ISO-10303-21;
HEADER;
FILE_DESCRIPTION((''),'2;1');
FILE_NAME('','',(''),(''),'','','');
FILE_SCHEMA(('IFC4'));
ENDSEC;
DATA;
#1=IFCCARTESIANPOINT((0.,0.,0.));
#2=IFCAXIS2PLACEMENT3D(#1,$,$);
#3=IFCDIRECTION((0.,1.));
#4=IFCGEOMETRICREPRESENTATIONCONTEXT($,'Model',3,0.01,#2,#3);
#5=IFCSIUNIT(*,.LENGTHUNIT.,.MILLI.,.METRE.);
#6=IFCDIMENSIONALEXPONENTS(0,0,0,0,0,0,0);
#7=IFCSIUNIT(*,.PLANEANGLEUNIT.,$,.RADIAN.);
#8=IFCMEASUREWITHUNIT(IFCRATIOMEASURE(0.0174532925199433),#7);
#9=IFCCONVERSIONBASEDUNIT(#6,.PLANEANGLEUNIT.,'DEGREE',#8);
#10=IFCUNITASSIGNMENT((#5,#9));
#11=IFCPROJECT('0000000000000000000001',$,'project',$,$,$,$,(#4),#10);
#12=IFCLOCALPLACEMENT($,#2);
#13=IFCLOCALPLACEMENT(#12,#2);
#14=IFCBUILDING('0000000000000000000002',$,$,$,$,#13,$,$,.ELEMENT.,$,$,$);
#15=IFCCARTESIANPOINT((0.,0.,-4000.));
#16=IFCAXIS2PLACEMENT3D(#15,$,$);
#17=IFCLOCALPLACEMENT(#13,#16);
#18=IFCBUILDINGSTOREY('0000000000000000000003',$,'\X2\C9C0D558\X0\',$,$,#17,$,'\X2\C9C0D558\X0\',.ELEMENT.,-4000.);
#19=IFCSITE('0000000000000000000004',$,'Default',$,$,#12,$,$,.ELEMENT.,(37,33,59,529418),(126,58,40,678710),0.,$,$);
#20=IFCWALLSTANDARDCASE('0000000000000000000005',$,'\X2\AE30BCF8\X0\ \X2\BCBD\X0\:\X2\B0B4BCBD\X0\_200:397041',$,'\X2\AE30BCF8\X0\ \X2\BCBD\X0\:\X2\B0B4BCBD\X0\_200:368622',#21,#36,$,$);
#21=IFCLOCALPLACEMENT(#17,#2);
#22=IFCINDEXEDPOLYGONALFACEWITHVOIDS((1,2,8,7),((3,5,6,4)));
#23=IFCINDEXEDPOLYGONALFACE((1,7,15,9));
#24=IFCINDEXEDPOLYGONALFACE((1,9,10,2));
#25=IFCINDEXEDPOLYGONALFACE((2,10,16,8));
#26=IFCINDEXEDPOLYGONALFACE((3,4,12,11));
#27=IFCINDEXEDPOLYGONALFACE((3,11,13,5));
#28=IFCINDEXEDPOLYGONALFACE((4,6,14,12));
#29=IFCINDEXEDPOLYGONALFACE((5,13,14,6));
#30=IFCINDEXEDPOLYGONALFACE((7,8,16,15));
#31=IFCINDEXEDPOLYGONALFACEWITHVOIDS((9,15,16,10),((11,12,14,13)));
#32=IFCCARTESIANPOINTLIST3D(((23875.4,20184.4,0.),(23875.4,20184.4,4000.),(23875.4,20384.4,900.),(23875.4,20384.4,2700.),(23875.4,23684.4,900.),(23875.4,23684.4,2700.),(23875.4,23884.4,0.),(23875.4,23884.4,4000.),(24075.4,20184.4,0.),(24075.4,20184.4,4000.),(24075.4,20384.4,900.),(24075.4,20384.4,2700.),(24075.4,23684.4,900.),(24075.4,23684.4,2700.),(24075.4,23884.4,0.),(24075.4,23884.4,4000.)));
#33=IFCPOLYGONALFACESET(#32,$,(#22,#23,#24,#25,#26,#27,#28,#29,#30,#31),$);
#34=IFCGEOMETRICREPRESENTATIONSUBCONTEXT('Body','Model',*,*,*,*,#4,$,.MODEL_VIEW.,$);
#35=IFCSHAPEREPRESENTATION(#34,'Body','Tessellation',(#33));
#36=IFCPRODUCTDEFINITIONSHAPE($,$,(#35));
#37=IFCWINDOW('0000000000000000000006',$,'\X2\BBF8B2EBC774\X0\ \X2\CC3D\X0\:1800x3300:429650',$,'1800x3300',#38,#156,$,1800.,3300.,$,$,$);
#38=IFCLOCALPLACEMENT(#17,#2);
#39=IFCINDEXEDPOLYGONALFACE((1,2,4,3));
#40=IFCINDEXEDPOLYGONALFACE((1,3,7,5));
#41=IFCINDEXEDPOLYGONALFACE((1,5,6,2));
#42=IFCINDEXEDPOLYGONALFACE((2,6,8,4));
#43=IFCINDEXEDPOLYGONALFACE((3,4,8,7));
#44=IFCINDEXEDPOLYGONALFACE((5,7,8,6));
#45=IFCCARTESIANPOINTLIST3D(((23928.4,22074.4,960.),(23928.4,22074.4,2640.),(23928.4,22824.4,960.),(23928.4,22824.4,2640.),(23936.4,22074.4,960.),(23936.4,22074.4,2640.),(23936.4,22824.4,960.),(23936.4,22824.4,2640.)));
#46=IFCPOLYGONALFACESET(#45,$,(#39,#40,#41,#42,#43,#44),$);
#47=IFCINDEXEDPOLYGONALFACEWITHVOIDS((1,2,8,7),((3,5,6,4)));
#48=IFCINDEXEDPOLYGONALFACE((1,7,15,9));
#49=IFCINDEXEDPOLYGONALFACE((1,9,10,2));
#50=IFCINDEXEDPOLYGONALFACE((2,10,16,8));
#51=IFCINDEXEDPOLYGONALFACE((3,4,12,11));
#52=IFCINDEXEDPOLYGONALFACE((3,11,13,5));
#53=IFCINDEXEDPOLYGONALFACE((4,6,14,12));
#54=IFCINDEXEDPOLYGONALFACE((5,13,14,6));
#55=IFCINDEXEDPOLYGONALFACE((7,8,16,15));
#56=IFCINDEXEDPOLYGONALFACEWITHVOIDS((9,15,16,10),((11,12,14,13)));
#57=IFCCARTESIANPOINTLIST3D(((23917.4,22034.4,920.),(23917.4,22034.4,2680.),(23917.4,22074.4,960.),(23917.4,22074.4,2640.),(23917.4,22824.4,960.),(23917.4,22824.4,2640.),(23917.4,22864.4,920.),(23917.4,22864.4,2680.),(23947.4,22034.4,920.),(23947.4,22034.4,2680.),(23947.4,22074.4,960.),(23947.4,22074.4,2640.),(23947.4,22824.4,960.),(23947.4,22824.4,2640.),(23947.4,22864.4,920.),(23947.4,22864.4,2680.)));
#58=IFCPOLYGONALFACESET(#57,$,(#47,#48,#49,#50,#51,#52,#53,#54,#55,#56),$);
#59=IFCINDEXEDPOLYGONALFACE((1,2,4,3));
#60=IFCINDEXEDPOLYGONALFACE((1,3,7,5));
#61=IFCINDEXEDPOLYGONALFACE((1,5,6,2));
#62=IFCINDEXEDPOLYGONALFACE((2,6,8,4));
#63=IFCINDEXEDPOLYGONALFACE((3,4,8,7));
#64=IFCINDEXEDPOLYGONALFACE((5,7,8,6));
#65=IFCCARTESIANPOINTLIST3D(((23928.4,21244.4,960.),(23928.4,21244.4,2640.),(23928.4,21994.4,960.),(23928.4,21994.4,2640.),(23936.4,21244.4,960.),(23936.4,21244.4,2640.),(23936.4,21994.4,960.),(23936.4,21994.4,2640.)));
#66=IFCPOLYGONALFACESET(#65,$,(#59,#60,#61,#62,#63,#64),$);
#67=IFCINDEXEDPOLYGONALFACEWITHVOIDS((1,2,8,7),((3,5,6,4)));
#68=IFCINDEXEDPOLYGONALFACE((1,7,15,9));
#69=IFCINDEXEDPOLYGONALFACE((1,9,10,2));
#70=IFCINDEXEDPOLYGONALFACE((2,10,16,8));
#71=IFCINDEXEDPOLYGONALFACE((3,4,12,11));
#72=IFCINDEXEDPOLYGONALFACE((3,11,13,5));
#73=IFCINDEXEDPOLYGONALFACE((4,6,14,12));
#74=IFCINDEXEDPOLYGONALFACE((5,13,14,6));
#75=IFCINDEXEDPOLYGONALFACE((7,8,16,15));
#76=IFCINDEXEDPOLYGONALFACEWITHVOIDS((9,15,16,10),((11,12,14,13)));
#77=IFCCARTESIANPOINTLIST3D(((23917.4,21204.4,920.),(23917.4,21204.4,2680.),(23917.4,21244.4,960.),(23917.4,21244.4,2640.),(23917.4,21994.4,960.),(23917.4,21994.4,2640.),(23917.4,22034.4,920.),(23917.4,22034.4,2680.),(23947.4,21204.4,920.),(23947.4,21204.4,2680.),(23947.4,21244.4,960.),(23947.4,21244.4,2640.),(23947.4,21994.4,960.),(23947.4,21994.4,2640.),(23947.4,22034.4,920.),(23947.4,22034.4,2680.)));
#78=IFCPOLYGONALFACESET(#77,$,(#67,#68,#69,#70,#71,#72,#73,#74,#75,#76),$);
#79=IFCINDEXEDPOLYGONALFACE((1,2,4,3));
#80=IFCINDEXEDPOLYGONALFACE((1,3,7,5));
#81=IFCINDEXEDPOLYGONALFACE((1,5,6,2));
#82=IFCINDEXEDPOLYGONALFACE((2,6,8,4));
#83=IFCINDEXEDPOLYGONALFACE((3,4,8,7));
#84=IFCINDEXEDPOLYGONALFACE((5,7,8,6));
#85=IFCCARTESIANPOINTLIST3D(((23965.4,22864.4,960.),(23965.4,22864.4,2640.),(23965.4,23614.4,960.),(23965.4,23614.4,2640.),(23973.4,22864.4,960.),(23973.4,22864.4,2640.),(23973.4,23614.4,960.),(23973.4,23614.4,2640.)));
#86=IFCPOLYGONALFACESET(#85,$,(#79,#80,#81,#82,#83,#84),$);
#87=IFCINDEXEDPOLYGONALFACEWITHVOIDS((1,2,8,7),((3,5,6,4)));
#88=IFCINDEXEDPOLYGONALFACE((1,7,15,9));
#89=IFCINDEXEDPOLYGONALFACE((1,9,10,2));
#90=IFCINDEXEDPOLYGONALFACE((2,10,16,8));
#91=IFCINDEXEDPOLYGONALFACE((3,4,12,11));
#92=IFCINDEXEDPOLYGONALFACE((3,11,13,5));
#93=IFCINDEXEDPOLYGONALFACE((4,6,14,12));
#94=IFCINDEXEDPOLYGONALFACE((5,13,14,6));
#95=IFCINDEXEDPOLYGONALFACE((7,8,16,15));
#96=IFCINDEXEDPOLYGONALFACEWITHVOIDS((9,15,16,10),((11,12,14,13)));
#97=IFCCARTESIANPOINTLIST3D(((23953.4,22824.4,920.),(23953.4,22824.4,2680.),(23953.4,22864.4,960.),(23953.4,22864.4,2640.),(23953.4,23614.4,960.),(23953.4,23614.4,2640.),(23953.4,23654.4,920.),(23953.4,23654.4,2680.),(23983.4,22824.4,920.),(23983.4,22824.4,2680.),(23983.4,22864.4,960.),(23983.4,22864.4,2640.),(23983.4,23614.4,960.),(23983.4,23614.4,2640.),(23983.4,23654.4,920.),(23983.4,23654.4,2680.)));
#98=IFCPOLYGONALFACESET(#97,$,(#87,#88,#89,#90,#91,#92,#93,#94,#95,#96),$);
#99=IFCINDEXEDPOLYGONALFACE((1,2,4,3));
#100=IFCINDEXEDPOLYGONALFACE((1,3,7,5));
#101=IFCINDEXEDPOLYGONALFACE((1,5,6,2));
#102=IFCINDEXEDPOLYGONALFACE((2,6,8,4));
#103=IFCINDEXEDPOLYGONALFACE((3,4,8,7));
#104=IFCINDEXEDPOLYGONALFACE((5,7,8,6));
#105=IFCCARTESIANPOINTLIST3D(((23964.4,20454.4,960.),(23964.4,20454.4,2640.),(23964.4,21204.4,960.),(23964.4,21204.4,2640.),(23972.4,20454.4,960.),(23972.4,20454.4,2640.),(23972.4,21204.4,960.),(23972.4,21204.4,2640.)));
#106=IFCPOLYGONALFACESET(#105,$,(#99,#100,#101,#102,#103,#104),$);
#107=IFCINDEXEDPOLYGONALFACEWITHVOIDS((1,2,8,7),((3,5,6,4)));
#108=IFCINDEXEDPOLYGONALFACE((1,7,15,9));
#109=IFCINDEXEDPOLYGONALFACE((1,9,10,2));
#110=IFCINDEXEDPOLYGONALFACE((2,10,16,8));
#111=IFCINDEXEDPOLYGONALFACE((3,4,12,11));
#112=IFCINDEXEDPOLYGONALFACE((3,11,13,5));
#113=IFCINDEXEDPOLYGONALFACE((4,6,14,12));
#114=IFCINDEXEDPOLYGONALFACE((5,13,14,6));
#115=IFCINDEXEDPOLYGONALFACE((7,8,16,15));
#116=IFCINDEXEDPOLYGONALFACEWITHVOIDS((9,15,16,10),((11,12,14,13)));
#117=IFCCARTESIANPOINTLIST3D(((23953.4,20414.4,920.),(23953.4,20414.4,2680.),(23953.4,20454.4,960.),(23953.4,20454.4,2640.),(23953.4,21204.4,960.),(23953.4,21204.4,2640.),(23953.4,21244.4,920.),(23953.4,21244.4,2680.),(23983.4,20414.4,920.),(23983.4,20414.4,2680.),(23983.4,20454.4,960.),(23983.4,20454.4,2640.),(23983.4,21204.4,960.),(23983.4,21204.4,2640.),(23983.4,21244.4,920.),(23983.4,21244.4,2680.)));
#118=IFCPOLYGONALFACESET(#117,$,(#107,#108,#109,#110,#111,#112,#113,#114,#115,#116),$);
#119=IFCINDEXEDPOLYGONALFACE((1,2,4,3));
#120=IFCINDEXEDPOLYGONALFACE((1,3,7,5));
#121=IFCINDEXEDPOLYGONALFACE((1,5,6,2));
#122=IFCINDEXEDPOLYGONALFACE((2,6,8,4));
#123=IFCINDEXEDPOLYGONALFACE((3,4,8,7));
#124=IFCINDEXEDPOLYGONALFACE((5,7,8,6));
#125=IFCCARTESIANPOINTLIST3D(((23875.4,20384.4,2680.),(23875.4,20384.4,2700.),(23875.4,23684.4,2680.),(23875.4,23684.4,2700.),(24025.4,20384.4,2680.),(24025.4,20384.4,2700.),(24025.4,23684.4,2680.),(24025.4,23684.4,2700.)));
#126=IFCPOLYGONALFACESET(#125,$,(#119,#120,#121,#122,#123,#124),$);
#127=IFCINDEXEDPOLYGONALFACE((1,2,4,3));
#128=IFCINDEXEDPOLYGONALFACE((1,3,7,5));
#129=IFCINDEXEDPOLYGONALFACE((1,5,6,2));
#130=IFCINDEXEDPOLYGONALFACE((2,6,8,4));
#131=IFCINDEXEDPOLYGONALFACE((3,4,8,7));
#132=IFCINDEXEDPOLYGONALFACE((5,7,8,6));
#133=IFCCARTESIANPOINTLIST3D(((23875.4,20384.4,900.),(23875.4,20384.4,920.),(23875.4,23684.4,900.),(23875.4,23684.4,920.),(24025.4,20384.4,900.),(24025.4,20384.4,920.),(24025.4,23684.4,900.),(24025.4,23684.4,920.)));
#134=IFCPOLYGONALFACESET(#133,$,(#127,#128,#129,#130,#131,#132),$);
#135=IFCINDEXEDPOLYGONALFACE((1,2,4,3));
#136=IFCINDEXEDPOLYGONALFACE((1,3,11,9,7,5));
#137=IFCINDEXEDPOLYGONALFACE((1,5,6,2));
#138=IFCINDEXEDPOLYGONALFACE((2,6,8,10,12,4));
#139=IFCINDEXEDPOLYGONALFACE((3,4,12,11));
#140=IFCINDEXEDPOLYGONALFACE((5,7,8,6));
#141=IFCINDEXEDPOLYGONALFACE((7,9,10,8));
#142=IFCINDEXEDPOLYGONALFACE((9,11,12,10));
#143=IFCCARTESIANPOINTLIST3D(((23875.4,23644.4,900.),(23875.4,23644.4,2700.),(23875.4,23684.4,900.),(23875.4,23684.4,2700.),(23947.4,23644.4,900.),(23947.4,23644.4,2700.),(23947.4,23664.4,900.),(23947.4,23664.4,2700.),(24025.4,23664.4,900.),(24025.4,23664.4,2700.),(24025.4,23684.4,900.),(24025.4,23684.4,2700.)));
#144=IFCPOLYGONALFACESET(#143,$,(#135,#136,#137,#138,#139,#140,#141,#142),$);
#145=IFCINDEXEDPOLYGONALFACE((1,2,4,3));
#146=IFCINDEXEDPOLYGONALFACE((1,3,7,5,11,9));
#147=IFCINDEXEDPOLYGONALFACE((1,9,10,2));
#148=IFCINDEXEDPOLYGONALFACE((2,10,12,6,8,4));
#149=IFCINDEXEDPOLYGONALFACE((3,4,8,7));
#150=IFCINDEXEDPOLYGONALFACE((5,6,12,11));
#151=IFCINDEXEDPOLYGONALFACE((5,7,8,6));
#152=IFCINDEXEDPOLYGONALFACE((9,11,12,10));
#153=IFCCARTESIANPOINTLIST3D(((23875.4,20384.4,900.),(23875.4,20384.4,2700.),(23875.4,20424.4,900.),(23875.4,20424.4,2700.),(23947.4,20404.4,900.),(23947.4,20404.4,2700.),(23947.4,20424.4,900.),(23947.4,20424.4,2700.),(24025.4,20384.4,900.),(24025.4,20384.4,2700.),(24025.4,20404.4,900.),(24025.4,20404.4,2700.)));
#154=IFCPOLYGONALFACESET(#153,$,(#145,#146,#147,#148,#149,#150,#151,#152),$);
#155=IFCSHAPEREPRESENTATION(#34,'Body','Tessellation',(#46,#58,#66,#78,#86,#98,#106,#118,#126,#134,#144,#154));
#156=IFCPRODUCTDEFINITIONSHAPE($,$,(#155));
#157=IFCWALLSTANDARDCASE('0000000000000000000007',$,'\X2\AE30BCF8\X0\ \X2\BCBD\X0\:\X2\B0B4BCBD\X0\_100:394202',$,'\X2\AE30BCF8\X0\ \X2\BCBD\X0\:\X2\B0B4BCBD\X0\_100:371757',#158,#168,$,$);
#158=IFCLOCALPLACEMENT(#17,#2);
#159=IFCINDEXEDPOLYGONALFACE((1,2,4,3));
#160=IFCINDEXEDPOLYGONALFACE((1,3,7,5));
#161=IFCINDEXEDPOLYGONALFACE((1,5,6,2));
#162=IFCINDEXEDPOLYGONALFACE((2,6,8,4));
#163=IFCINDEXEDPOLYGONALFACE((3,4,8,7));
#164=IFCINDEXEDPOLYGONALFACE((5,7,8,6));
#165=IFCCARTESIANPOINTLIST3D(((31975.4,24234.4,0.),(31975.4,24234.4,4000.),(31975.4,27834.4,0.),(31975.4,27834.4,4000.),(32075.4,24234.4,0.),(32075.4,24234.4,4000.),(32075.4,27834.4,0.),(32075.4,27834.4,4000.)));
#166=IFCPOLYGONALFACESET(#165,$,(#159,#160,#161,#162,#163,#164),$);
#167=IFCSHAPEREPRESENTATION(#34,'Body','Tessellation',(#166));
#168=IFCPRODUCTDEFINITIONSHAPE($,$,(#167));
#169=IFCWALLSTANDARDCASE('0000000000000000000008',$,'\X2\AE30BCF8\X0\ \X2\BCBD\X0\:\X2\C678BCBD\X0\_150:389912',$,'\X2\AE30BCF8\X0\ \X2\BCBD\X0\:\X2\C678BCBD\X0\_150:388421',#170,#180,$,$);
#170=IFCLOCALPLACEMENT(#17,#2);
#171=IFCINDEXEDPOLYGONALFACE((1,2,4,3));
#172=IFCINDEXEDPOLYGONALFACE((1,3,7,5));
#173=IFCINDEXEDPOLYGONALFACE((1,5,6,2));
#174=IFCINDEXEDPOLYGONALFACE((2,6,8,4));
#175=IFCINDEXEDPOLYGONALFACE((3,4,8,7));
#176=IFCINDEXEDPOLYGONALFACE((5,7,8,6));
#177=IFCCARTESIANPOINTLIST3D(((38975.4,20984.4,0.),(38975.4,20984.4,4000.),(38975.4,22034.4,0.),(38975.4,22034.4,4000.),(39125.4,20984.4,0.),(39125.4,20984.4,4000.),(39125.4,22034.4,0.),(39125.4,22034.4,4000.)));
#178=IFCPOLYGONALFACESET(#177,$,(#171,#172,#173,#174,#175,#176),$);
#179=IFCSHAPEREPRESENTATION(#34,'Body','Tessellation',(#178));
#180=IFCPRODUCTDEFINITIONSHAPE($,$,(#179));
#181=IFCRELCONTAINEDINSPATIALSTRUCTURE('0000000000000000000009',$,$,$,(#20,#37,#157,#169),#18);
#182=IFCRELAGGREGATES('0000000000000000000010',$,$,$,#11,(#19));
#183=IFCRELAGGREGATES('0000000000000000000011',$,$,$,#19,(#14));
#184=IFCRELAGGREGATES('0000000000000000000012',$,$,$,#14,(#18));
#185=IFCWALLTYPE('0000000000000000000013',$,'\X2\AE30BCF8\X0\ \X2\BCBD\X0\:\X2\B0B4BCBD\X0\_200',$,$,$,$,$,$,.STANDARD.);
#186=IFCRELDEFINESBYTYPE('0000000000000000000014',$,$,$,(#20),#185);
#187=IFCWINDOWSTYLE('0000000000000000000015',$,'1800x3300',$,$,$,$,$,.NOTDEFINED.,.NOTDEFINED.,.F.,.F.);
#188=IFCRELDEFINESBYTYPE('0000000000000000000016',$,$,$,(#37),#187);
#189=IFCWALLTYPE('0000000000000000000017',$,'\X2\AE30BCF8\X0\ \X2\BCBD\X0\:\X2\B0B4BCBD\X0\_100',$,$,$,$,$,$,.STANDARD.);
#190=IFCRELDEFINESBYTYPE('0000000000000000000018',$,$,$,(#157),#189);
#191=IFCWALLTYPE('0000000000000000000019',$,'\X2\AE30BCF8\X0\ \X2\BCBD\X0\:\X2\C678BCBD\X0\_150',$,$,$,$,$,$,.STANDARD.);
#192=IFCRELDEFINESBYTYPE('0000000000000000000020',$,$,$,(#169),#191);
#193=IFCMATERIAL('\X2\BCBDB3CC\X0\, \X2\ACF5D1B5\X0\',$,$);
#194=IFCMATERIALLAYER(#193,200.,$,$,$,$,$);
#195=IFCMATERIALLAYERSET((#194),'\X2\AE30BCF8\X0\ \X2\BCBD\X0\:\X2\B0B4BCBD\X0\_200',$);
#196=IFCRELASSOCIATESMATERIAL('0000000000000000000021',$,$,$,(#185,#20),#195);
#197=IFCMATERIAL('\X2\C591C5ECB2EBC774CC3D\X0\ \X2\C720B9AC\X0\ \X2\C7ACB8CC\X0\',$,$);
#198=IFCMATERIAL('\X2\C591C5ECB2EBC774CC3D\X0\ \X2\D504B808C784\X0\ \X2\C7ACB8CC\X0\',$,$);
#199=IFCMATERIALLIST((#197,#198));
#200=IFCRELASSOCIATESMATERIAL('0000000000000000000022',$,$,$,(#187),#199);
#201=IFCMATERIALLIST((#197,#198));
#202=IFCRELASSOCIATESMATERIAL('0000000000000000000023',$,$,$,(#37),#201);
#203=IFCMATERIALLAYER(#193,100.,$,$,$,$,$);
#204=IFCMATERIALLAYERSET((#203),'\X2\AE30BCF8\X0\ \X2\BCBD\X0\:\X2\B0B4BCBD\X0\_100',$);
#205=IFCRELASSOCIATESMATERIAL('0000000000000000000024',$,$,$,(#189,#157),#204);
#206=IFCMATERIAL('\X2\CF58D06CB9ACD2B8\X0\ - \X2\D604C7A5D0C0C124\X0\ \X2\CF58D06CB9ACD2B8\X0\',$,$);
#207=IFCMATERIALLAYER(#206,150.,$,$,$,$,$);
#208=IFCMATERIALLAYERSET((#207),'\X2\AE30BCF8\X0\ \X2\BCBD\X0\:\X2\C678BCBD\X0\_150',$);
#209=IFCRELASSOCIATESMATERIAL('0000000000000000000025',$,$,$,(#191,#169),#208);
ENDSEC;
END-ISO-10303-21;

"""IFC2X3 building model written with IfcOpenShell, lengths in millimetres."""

from ifc_helpers import new_model, entity, si_unit, converted_unit, direction, frame, frame_2d, origin, origin_2d_with_axis, place, context, subcontext, project, spatial, polyline, rectangle, outline, extrude, source, transform, mapped, material, material_list, layer, layer_set, layer_usage, type_object, type_shapes, element, fill, save


model = new_model("IFC2X3")

# Units and contexts
model_context = context("Model", 3, precision=0.01, world=origin(), true_north=direction((0.0, 1.0)))
body_context = subcontext(model_context, "Body", "Model", "MODEL_VIEW")
ifc_project = project(units=[si_unit("LENGTHUNIT", "METRE", prefix="MILLI"), converted_unit("PLANEANGLEUNIT", "DEGREE", entity("IfcRatioMeasure", 0.0174532925199433), si_unit("PLANEANGLEUNIT", "RADIAN"), dimensions=[0, 0, 0, 0, 0, 0, 0])], contexts=[model_context])

# Site, building, storey
site_placement = place(None, origin())
site = spatial("IfcSite", under=ifc_project, at=site_placement, Name="Default", CompositionType="ELEMENT", RefLatitude=(37, 33, 59, 529418), RefLongitude=(126, 58, 40, 678710), RefElevation=0.0)
building_placement = place(site_placement, origin())
building = spatial("IfcBuilding", under=site, at=building_placement, CompositionType="ELEMENT")
storey_placement = place(building_placement, frame((0.0, 0.0, -4000.0)))
storey = spatial("IfcBuildingStorey", under=building, at=storey_placement, Name="지하", LongName="지하", CompositionType="ELEMENT", Elevation=-4000.0)

# Shared definitions
ifc_material_1 = material(Name="콘크리트 - 현장타설 콘크리트")

# Shared definitions
ifc_material_2 = material(Name="양여닫이창 유리 재료")
ifc_material_3 = material(Name="양여닫이창 프레임 재료")

# Shared definitions
ifc_material_4 = material(Name="벽돌, 공통")
ifc_layer_1 = layer(ifc_material_4, 200.0)
ifc_layer_set_1 = layer_set([ifc_layer_1], Name="기본 벽:내벽_200")
wall_type_1 = type_object("IfcWallType", Name="기본 벽:내벽_200", PredefinedType="STANDARD", material=ifc_layer_set_1)

# Wall, opening, window
ifc_material_list_1 = material_list([ifc_material_2, ifc_material_3])
window_style_1 = type_object("IfcWindowStyle", Name="1800x3300", ConstructionType="NOTDEFINED", OperationType="NOTDEFINED", ParameterTakesPrecedence=False, Sizeable=False, material=ifc_material_list_1)
shared_shape_1 = source(origin(), body_context, "Body", "SweptSolid", [
    extrude(rectangle(XDim=8.0, YDim=750.0, at=frame_2d((0.0, 0.0), x_axis=(1.0, 0.0))), frame((2065.0, 143.0, 60.0), z_axis=(0.0, 0.0, 1.0), x_axis=(0.0, 1.0, 0.0)), (0.0, 0.0, 1.0), 1680.0),
    extrude(outline(polyline([(-880.0, -415.0), (880.0, -415.0), (880.0, 415.0), (-880.0, 415.0), (-880.0, -415.0)]), holes=[polyline([(840.0, -375.0), (-840.0, -375.0), (-840.0, 375.0), (840.0, 375.0), (840.0, -375.0)])]), frame((2065.0, 128.0, 900.0), z_axis=(0.0, 1.0, 0.0), x_axis=(0.0, 0.0, -1.0)), (0.0, 0.0, 1.0), 30.0),
    extrude(rectangle(XDim=8.0, YDim=750.0, at=frame_2d((0.0, 0.0), x_axis=(1.0, 0.0))), frame((1235.0, 143.0, 60.0), z_axis=(0.0, 0.0, 1.0), x_axis=(0.0, 1.0, 0.0)), (0.0, 0.0, 1.0), 1680.0),
    extrude(outline(polyline([(-880.0, -415.0), (880.0, -415.0), (880.0, 415.0), (-880.0, 415.0), (-880.0, -415.0)]), holes=[polyline([(840.0, -375.0), (-840.0, -375.0), (-840.0, 375.0), (840.0, 375.0), (840.0, -375.0)])]), frame((1235.0, 128.0, 900.0), z_axis=(0.0, 1.0, 0.0), x_axis=(0.0, 0.0, -1.0)), (0.0, 0.0, 1.0), 30.0),
    extrude(rectangle(XDim=8.0, YDim=750.0, at=frame_2d((0.0, 0.0), x_axis=(1.0, 0.0))), frame((2855.0, 106.0, 60.0), z_axis=(0.0, 0.0, 1.0), x_axis=(0.0, 1.0, 0.0)), (0.0, 0.0, 1.0), 1680.0),
    extrude(outline(polyline([(-880.0, -415.0), (880.0, -415.0), (880.0, 415.0), (-880.0, 415.0), (-880.0, -415.0)]), holes=[polyline([(840.0, -375.0), (-840.0, -375.0), (-840.0, 375.0), (840.0, 375.0), (840.0, -375.0)])]), frame((2855.0, 92.0, 900.0), z_axis=(0.0, 1.0, 0.0), x_axis=(0.0, 0.0, -1.0)), (0.0, 0.0, 1.0), 30.0),
    extrude(rectangle(XDim=8.0, YDim=750.0, at=origin_2d_with_axis()), frame((445.0, 107.0, 60.0), z_axis=(0.0, 0.0, 1.0), x_axis=(0.0, 1.0, 0.0)), (0.0, 0.0, 1.0), 1680.0),
    extrude(outline(polyline([(-880.0, -415.0), (880.0, -415.0), (880.0, 415.0), (-880.0, 415.0), (-880.0, -415.0)]), holes=[polyline([(840.0, -375.0), (-840.0, -375.0), (-840.0, 375.0), (840.0, 375.0), (840.0, -375.0)])]), frame((445.0, 92.0, 900.0), z_axis=(0.0, 1.0, 0.0), x_axis=(0.0, 0.0, -1.0)), (0.0, 0.0, 1.0), 30.0),
    extrude(rectangle(XDim=3300.0, YDim=150.0, at=origin_2d_with_axis()), frame((1650.0, 125.0, 1780.0), z_axis=(0.0, 0.0, 1.0), x_axis=(-1.0, 0.0, 0.0)), (0.0, 0.0, 1.0), 20.0),
    extrude(rectangle(XDim=3300.0, YDim=150.0, at=origin_2d_with_axis()), frame((1650.0, 125.0, 0.0), z_axis=(0.0, 0.0, 1.0), x_axis=(-1.0, 0.0, 0.0)), (0.0, 0.0, 1.0), 20.0),
    extrude(outline(polyline([(-74.0, -20.0), (-2.0, -20.0), (-2.0, 0.0), (76.0, 0.0), (76.0, 20.0), (-74.0, 20.0), (-74.0, -20.0)])), frame((3280.0, 126.0, 0.0), z_axis=(0.0, 0.0, 1.0), x_axis=(0.0, -1.0, 0.0)), (0.0, 0.0, 1.0), 1800.0),
    extrude(outline(polyline([(-20.0, -74.0), (20.0, -74.0), (20.0, 76.0), (0.0, 76.0), (0.0, -2.0), (-20.0, -2.0), (-20.0, -74.0)])), frame((20.0, 126.0, 0.0), z_axis=(0.0, 0.0, 1.0), x_axis=(-1.0, 0.0, 0.0)), (0.0, 0.0, 1.0), 1800.0),
])
type_shapes(window_style_1, [shared_shape_1])
ifc_layer_usage_1 = layer_usage(ifc_layer_set_1, "AXIS2", "NEGATIVE", 100.0)
wall_1_placement = place(storey_placement, frame((23975.4, 23884.4, 0.0), z_axis=(0.0, 0.0, 1.0), x_axis=(0.0, -1.0, 0.0)))
wall_1 = element("IfcWallStandardCase", 1, at=wall_1_placement, inside=storey, type_object=wall_type_1, material=ifc_layer_usage_1, Name="기본 벽:내벽_200:397041", ObjectType="기본 벽:내벽_200:368622", context=body_context, shape_type="SweptSolid", body=[
    extrude(rectangle(XDim=3700.0, YDim=200.0, at=frame_2d((1850.0, 0.0), x_axis=(-1.0, 0.0))), origin(), (0.0, 0.0, 1.0), 4000.0),
])
opening_1_placement = place(wall_1_placement, frame((3500.0, 100.0, 900.0)))
opening_1 = element("IfcOpeningElement", 2, at=opening_1_placement, cuts=wall_1, ObjectType="Opening", context=body_context, shape_type="SweptSolid", body=[
    extrude(rectangle(XDim=1800.0, YDim=3300.0, at=frame_2d((900.0, 1650.0), x_axis=(1.0, 0.0))), frame((0.0, 0.0, 0.0), z_axis=(0.0, -1.0, 0.0), x_axis=(0.0, 0.0, 1.0)), (0.0, 0.0, 1.0), 200.0),
])
ifc_material_list_2 = material_list([ifc_material_2, ifc_material_3])
window_1_placement = place(opening_1_placement, frame((0.0, 0.0, 0.0), z_axis=(0.0, 0.0, 1.0), x_axis=(-1.0, 0.0, 0.0)))
window_1 = element("IfcWindow", 3, at=window_1_placement, inside=storey, type_object=window_style_1, material=ifc_material_list_2, Name="미닫이 창:1800x3300:429650", ObjectType="1800x3300", OverallHeight=1800.0, OverallWidth=3300.0, context=body_context, shape_type="MappedRepresentation", body=[
    mapped(shared_shape_1, transform((0.0, 0.0, 0.0), scale=1.0)),
])
fill(opening_1, window_1)

# Walls
ifc_layer_2 = layer(ifc_material_4, 100.0)
ifc_layer_set_2 = layer_set([ifc_layer_2], Name="기본 벽:내벽_100")
ifc_layer_usage_2 = layer_usage(ifc_layer_set_2, "AXIS2", "NEGATIVE", 50.0)
wall_type_2 = type_object("IfcWallType", Name="기본 벽:내벽_100", PredefinedType="STANDARD", material=ifc_layer_set_2)
wall_2_placement = place(storey_placement, frame((32025.4, 24234.4, 0.0), z_axis=(0.0, 0.0, 1.0), x_axis=(0.0, 1.0, 0.0)))
element("IfcWallStandardCase", 4, at=wall_2_placement, inside=storey, type_object=wall_type_2, material=ifc_layer_usage_2, Name="기본 벽:내벽_100:394202", ObjectType="기본 벽:내벽_100:371757", context=body_context, shape_type="SweptSolid", body=[
    extrude(rectangle(XDim=3600.0, YDim=100.0, at=frame_2d((1800.0, 0.0), x_axis=(-1.0, 0.0))), origin(), (0.0, 0.0, 1.0), 4000.0),
])
ifc_layer_3 = layer(ifc_material_1, 150.0)
ifc_layer_set_3 = layer_set([ifc_layer_3], Name="기본 벽:외벽_150")
ifc_layer_usage_3 = layer_usage(ifc_layer_set_3, "AXIS2", "NEGATIVE", 75.0)
wall_type_3 = type_object("IfcWallType", Name="기본 벽:외벽_150", PredefinedType="STANDARD", material=ifc_layer_set_3)
wall_3_placement = place(storey_placement, frame((39050.4, 22034.4, 0.0), z_axis=(0.0, 0.0, 1.0), x_axis=(0.0, -1.0, 0.0)))
element("IfcWallStandardCase", 5, at=wall_3_placement, inside=storey, type_object=wall_type_3, material=ifc_layer_usage_3, Name="기본 벽:외벽_150:389912", ObjectType="기본 벽:외벽_150:388421", context=body_context, shape_type="SweptSolid", body=[
    extrude(rectangle(XDim=1050.0, YDim=150.0, at=frame_2d((525.0, 0.0), x_axis=(-1.0, 0.0))), origin(), (0.0, 0.0, 1.0), 4000.0),
])

save(model, "model.ifc")
